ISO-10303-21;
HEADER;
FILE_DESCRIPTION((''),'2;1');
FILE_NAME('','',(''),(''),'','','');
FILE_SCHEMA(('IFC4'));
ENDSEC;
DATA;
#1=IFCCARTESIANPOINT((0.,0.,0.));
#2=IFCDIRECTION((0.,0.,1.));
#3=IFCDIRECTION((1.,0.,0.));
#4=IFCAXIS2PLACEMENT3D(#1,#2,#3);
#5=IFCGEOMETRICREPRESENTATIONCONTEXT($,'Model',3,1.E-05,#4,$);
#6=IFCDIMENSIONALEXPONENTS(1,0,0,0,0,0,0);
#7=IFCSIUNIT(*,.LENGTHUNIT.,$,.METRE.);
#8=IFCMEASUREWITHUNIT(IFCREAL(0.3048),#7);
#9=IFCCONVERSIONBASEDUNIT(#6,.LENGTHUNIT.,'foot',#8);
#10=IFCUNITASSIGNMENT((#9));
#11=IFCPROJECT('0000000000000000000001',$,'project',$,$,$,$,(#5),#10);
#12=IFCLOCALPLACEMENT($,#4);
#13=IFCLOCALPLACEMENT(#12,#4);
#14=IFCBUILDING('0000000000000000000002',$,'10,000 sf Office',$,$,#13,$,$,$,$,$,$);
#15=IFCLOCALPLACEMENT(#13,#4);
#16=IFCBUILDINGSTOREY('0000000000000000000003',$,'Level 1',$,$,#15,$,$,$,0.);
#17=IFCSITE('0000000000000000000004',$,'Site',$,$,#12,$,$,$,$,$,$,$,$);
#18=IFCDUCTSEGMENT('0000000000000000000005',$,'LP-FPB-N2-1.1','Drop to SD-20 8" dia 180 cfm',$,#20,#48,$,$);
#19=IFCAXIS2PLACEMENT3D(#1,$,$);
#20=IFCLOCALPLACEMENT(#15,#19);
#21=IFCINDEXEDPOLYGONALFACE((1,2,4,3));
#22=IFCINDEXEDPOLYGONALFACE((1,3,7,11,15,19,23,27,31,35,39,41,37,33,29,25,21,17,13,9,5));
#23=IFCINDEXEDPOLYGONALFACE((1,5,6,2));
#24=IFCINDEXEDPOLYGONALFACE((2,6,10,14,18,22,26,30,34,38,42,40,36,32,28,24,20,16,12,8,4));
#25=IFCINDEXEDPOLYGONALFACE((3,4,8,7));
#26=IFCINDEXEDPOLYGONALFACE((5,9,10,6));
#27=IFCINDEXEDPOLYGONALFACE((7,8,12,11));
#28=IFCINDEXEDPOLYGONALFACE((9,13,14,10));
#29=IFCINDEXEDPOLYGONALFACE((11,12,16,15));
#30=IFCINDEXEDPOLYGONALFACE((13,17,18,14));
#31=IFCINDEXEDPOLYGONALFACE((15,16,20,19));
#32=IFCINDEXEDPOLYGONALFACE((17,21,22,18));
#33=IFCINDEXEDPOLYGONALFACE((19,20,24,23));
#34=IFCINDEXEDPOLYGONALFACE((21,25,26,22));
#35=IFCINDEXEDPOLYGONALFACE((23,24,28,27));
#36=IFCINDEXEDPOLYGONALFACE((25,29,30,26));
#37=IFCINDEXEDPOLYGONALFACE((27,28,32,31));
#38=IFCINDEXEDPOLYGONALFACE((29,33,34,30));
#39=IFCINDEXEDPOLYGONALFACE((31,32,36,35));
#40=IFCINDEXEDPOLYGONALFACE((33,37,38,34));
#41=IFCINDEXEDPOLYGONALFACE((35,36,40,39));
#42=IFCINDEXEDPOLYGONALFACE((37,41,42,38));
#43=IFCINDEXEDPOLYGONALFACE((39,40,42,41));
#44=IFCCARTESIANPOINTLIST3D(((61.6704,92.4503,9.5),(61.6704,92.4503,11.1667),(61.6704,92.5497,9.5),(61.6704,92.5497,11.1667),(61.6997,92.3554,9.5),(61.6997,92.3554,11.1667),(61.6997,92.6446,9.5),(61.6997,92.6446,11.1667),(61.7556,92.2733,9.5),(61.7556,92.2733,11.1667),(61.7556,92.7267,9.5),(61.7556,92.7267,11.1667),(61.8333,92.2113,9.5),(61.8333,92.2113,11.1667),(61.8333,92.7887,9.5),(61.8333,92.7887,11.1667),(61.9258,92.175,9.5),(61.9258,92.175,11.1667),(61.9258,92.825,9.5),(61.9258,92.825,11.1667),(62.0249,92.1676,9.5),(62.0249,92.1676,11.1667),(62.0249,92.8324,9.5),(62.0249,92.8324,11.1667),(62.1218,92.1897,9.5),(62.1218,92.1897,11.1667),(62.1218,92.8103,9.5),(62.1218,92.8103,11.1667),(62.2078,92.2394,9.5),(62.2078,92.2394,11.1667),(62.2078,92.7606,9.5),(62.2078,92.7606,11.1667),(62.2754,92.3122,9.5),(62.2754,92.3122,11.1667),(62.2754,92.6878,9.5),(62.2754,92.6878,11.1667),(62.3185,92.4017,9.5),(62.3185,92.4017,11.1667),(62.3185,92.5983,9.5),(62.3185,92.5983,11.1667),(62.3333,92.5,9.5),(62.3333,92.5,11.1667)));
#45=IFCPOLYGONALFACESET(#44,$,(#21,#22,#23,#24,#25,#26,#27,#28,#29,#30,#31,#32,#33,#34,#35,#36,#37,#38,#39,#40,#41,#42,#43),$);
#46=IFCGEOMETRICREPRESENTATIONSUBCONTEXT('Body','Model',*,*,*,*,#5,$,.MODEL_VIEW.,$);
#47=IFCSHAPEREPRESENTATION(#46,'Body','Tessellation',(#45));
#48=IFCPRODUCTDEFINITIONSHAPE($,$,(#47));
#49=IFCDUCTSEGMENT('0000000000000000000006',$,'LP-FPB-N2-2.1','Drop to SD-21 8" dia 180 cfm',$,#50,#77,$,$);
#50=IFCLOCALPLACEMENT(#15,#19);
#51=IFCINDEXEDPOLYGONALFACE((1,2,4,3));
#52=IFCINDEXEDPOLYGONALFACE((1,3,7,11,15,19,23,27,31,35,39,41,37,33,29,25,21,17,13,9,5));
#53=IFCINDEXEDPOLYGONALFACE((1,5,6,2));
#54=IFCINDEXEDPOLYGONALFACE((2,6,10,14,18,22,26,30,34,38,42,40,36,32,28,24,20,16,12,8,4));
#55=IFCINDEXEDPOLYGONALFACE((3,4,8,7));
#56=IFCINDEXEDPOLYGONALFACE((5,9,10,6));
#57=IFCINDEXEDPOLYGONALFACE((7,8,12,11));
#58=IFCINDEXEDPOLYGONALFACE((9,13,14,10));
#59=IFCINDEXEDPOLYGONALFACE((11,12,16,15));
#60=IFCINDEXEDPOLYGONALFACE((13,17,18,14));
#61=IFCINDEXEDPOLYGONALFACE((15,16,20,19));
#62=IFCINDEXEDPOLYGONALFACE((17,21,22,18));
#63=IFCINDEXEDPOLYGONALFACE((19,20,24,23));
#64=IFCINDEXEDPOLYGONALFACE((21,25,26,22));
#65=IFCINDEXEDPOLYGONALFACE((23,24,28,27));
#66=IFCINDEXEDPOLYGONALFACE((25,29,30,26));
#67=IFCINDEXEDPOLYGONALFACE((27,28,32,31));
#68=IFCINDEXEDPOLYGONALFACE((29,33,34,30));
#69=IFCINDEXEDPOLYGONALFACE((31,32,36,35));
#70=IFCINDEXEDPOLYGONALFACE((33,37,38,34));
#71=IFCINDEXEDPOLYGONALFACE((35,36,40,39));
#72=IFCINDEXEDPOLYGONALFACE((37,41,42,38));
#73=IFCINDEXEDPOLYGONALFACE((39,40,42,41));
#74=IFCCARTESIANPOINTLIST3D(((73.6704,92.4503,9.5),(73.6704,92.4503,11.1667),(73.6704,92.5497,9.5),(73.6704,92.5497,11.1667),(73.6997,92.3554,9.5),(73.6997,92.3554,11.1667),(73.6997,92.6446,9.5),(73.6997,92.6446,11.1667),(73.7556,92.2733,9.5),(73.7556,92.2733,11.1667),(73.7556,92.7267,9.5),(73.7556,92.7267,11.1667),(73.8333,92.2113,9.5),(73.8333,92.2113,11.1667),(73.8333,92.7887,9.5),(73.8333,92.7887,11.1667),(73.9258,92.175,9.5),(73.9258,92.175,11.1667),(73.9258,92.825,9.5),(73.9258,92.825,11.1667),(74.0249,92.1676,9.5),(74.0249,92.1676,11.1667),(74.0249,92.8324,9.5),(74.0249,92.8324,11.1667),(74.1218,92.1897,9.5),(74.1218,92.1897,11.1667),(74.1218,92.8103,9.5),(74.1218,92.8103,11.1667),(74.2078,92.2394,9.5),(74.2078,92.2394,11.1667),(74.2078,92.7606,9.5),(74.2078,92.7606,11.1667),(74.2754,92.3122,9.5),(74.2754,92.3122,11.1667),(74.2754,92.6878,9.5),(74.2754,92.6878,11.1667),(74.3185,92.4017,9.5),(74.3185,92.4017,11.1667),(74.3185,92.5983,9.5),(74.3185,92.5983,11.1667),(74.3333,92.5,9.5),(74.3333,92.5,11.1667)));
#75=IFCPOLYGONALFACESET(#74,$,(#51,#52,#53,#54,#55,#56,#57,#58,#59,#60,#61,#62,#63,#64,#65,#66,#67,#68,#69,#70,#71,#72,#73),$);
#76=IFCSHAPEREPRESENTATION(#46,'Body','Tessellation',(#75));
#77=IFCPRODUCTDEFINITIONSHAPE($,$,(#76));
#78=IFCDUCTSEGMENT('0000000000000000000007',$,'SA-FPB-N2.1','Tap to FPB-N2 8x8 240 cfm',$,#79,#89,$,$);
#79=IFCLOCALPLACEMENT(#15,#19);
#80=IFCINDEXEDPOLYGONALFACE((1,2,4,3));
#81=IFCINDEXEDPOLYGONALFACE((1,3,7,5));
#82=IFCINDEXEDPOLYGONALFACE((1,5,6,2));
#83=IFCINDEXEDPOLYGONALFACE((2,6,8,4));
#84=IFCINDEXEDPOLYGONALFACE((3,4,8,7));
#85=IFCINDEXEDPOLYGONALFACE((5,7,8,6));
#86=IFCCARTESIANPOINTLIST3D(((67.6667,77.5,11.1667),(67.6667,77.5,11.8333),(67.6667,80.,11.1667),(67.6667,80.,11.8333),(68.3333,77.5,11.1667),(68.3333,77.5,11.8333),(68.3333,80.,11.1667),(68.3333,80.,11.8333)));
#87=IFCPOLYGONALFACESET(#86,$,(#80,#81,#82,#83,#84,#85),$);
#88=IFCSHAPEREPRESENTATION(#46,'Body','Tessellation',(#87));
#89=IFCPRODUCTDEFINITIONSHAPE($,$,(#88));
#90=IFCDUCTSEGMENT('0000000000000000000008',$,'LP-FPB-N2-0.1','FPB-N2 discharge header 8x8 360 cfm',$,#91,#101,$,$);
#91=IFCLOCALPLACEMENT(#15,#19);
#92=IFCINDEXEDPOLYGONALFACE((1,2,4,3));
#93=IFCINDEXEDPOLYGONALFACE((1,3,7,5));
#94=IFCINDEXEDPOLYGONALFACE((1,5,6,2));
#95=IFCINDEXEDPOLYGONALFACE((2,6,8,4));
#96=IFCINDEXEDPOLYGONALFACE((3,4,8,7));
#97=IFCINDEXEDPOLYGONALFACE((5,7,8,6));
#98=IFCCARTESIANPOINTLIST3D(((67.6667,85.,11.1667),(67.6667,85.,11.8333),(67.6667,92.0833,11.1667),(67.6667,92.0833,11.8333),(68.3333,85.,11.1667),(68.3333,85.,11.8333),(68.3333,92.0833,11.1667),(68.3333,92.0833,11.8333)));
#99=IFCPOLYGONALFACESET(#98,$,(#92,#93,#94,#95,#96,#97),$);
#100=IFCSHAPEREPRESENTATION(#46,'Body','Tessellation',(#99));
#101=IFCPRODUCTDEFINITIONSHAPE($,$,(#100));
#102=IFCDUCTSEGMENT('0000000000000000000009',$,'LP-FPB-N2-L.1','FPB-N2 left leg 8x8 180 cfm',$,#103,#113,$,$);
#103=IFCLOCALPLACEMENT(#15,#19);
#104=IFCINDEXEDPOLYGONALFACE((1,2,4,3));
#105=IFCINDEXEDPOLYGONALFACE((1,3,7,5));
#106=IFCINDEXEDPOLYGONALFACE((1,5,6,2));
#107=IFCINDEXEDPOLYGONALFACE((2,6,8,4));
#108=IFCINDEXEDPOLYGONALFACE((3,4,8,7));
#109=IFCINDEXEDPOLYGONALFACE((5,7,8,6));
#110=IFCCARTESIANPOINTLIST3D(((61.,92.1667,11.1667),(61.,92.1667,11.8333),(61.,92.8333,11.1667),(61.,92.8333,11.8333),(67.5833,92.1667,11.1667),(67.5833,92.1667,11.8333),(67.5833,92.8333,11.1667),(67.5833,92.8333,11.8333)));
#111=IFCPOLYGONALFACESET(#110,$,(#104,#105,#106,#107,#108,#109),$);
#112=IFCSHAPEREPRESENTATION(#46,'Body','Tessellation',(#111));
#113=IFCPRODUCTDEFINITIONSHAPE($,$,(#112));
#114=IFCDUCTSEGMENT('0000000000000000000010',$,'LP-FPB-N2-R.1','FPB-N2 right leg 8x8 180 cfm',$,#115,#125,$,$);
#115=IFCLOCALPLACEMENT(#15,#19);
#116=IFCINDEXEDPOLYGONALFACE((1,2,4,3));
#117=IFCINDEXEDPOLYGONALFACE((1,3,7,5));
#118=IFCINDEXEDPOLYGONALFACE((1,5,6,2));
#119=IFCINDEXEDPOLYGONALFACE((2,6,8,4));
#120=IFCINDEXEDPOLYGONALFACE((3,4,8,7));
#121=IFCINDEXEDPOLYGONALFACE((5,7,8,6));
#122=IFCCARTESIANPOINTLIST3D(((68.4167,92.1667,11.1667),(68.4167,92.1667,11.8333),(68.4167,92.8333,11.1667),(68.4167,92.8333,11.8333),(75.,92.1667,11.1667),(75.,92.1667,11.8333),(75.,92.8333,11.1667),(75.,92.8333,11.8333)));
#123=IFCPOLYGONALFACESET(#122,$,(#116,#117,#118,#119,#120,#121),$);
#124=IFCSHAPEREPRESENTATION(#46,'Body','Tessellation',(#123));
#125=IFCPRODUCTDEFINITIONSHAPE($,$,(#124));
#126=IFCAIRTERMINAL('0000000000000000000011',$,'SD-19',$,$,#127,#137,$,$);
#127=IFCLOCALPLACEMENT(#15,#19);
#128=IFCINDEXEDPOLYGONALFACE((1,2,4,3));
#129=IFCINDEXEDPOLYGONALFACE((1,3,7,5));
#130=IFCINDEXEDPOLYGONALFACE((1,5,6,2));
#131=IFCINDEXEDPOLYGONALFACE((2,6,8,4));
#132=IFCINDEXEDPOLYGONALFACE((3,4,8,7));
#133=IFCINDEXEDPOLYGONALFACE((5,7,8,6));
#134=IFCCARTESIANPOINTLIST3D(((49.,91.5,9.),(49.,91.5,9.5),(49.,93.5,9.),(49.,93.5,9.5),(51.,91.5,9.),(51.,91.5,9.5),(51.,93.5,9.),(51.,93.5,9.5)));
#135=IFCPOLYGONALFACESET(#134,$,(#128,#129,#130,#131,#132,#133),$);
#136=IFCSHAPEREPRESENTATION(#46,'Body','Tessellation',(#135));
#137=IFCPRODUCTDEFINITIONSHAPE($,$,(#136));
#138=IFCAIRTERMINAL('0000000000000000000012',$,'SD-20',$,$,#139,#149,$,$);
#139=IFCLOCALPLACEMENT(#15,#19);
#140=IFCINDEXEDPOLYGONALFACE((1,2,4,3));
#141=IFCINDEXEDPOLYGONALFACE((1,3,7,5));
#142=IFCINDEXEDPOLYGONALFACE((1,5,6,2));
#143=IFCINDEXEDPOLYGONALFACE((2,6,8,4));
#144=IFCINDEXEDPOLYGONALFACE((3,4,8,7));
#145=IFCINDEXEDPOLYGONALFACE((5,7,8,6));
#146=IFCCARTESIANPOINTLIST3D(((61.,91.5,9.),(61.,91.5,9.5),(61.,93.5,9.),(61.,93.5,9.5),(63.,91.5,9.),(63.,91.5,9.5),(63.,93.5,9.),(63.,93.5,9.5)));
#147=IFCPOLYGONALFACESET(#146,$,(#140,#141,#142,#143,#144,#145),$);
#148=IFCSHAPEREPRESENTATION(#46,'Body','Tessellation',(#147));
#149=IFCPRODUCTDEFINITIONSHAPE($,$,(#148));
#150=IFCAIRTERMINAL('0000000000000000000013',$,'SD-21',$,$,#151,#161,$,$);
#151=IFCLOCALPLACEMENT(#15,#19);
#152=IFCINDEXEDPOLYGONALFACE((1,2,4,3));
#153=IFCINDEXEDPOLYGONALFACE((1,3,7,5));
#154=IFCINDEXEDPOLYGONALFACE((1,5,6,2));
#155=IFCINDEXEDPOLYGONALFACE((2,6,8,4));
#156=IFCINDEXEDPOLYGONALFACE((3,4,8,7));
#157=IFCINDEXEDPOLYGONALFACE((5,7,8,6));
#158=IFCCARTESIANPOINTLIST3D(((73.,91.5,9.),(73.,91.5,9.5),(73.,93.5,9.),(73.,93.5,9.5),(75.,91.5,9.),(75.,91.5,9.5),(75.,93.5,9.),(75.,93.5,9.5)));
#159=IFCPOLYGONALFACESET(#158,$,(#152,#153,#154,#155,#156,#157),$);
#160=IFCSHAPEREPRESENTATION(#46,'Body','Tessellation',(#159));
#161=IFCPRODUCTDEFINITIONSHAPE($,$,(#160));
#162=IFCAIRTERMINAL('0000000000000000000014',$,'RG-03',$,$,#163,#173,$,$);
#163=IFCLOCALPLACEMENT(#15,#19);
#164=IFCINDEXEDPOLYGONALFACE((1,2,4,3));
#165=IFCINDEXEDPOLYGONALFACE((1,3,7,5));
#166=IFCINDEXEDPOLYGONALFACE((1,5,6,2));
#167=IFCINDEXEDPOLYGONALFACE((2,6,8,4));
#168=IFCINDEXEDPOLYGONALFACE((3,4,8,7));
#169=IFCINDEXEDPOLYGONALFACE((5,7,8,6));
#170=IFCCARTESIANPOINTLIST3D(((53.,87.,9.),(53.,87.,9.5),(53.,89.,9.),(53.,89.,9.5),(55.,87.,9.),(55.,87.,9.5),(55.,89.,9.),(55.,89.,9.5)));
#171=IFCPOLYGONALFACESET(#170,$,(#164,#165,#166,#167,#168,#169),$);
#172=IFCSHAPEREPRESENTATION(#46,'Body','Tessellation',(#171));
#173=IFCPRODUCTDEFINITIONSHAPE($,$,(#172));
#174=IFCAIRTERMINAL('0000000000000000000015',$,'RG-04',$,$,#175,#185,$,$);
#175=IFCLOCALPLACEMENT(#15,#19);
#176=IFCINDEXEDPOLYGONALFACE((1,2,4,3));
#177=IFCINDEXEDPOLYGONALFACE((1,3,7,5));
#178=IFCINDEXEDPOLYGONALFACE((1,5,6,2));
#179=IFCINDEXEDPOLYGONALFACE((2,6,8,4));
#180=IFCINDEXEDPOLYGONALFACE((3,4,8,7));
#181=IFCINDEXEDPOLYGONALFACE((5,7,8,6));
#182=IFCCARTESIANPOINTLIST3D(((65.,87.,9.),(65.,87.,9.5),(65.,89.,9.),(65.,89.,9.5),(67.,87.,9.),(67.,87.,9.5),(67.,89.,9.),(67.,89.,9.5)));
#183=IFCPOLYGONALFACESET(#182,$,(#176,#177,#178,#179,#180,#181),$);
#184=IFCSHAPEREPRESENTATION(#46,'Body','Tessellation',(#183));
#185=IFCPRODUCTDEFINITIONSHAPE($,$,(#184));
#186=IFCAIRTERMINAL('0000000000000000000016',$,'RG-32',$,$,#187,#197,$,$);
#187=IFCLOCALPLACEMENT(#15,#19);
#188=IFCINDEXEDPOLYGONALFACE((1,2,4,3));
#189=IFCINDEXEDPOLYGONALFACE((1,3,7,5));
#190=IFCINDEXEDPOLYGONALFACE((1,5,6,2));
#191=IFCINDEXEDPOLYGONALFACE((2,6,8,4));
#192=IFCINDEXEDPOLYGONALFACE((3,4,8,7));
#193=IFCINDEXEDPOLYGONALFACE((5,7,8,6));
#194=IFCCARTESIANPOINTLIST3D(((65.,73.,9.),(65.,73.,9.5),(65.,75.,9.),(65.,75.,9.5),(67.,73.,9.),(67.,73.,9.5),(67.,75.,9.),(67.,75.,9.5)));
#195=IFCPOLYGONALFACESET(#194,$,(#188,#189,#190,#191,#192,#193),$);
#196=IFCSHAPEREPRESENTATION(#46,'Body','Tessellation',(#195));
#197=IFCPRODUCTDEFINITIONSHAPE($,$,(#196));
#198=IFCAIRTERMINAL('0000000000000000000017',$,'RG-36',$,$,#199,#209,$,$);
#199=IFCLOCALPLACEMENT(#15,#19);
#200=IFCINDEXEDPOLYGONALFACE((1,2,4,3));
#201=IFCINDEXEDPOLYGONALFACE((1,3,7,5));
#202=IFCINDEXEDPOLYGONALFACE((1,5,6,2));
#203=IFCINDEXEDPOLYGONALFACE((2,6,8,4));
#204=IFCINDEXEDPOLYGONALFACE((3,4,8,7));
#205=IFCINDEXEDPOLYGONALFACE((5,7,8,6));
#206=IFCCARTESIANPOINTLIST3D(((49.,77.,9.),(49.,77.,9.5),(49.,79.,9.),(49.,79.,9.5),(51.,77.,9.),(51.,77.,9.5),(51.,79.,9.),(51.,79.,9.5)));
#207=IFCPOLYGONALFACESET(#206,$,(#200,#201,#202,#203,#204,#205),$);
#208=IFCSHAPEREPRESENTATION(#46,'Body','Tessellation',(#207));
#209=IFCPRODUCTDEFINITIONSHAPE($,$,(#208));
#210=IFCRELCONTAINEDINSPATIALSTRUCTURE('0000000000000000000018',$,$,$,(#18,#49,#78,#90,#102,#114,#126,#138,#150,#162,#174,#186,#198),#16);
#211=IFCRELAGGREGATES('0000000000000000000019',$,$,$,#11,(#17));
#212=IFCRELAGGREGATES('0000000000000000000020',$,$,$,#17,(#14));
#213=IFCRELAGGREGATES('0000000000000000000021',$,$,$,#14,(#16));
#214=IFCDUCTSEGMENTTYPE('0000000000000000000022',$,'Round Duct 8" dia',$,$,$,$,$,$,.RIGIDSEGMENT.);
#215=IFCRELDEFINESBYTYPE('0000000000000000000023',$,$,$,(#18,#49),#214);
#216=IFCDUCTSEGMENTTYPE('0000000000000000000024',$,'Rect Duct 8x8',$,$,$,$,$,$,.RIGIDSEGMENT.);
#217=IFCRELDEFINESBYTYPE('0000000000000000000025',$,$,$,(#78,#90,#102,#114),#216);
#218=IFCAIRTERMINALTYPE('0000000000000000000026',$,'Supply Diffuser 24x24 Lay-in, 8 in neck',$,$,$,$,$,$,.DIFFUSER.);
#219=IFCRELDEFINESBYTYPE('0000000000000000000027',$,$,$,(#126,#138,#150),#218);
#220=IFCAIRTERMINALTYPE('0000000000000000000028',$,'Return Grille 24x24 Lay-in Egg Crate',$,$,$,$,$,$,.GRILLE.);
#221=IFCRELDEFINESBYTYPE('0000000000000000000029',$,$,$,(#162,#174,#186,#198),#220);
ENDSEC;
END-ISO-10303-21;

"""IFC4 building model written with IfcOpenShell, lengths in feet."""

from ifc_helpers import new_model, entity, si_unit, converted_unit, frame, origin_with_axes, place, context, subcontext, project, spatial, rectangle, circle, extrude, type_object, element, save


model = new_model("IFC4")

# Units and contexts
model_context = context("Model", 3, precision=1e-05, world=origin_with_axes())
body_context = subcontext(model_context, "Body", "Model", "MODEL_VIEW")
ifc_project = project(units=[converted_unit("LENGTHUNIT", "foot", entity("IfcReal", 0.3048), si_unit("LENGTHUNIT", "METRE"), dimensions=[1, 0, 0, 0, 0, 0, 0])], contexts=[model_context])

# Site, building, storey
site_placement = place(None, origin_with_axes())
site = spatial("IfcSite", under=ifc_project, at=site_placement, Name="Site")
building_placement = place(site_placement, origin_with_axes())
building = spatial("IfcBuilding", under=site, at=building_placement, Name="10,000 sf Office")
storey_placement = place(building_placement, origin_with_axes())
storey = spatial("IfcBuildingStorey", under=building, at=storey_placement, Name="Level 1", Elevation=0.0)

# Duct segments
duct_segment_type_1 = type_object("IfcDuctSegmentType", Name="Round Duct 8\" dia", PredefinedType="RIGIDSEGMENT")
for number, where, z_axis, x_axis, name, description in (
    (1, (62.0, 92.5, 11.1667), (0.0, 0.0, -1.0), (1.0, 0.0, 0.0), "LP-FPB-N2-1.1", "Drop to SD-20 8\" dia 180 cfm"),
    (2, (74.0, 92.5, 11.1667), (0.0, 0.0, -1.0), (1.0, 0.0, 0.0), "LP-FPB-N2-2.1", "Drop to SD-21 8\" dia 180 cfm"),
):
    element("IfcDuctSegment", number, at=place(storey_placement, frame(where, z_axis=z_axis, x_axis=x_axis)), inside=storey, type_object=duct_segment_type_1, Name=name, Description=description, context=body_context, shape_type="SweptSolid", body=[
        extrude(circle(Radius=0.3333), None, (0.0, 0.0, 1.0), 1.6667),
    ])
duct_segment_type_2 = type_object("IfcDuctSegmentType", Name="Rect Duct 8x8", PredefinedType="RIGIDSEGMENT")
duct_segment_1_placement = place(storey_placement, frame((68.0, 77.5, 11.5), z_axis=(0.0, 1.0, 0.0), x_axis=(-1.0, 0.0, 0.0)))
element("IfcDuctSegment", 3, at=duct_segment_1_placement, inside=storey, type_object=duct_segment_type_2, Name="SA-FPB-N2.1", Description="Tap to FPB-N2 8x8 240 cfm", context=body_context, shape_type="SweptSolid", body=[
    extrude(rectangle(XDim=0.6667, YDim=0.6667), None, (0.0, 0.0, 1.0), 2.5),
])
duct_segment_2_placement = place(storey_placement, frame((68.0, 85.0, 11.5), z_axis=(0.0, 1.0, 0.0), x_axis=(-1.0, 0.0, 0.0)))
element("IfcDuctSegment", 4, at=duct_segment_2_placement, inside=storey, type_object=duct_segment_type_2, Name="LP-FPB-N2-0.1", Description="FPB-N2 discharge header 8x8 360 cfm", context=body_context, shape_type="SweptSolid", body=[
    extrude(rectangle(XDim=0.6667, YDim=0.6667), None, (0.0, 0.0, 1.0), 7.0833),
])
for number, where, z_axis, x_axis, name, description in (
    (5, (67.5833, 92.5, 11.5), (-1.0, 0.0, 0.0), (0.0, -1.0, 0.0), "LP-FPB-N2-L.1", "FPB-N2 left leg 8x8 180 cfm"),
    (6, (68.4167, 92.5, 11.5), (1.0, 0.0, 0.0), (0.0, 1.0, 0.0), "LP-FPB-N2-R.1", "FPB-N2 right leg 8x8 180 cfm"),
):
    element("IfcDuctSegment", number, at=place(storey_placement, frame(where, z_axis=z_axis, x_axis=x_axis)), inside=storey, type_object=duct_segment_type_2, Name=name, Description=description, context=body_context, shape_type="SweptSolid", body=[
        extrude(rectangle(XDim=0.6667, YDim=0.6667), None, (0.0, 0.0, 1.0), 6.5833),
    ])

# Air terminals
air_terminal_type_1 = type_object("IfcAirTerminalType", Name="Supply Diffuser 24x24 Lay-in, 8 in neck", PredefinedType="DIFFUSER")
for number, where, z_axis, x_axis, name in (
    (7, (50.0, 92.5, 9.0), (0.0, 0.0, 1.0), (1.0, 0.0, 0.0), "SD-19"),
    (8, (62.0, 92.5, 9.0), (0.0, 0.0, 1.0), (1.0, 0.0, 0.0), "SD-20"),
    (9, (74.0, 92.5, 9.0), (0.0, 0.0, 1.0), (1.0, 0.0, 0.0), "SD-21"),
):
    element("IfcAirTerminal", number, at=place(storey_placement, frame(where, z_axis=z_axis, x_axis=x_axis)), inside=storey, type_object=air_terminal_type_1, Name=name, context=body_context, shape_type="SweptSolid", body=[
        extrude(rectangle(XDim=2.0, YDim=2.0), None, (0.0, 0.0, 1.0), 0.5),
    ])
air_terminal_type_2 = type_object("IfcAirTerminalType", Name="Return Grille 24x24 Lay-in Egg Crate", PredefinedType="GRILLE")
for number, where, z_axis, x_axis, name in (
    (10, (54.0, 88.0, 9.0), (0.0, 0.0, 1.0), (1.0, 0.0, 0.0), "RG-03"),
    (11, (66.0, 88.0, 9.0), (0.0, 0.0, 1.0), (1.0, 0.0, 0.0), "RG-04"),
    (12, (66.0, 74.0, 9.0), (0.0, 0.0, 1.0), (1.0, 0.0, 0.0), "RG-32"),
    (13, (50.0, 78.0, 9.0), (0.0, 0.0, 1.0), (1.0, 0.0, 0.0), "RG-36"),
):
    element("IfcAirTerminal", number, at=place(storey_placement, frame(where, z_axis=z_axis, x_axis=x_axis)), inside=storey, type_object=air_terminal_type_2, Name=name, context=body_context, shape_type="SweptSolid", body=[
        extrude(rectangle(XDim=2.0, YDim=2.0), None, (0.0, 0.0, 1.0), 0.5),
    ])

save(model, "model.ifc")
